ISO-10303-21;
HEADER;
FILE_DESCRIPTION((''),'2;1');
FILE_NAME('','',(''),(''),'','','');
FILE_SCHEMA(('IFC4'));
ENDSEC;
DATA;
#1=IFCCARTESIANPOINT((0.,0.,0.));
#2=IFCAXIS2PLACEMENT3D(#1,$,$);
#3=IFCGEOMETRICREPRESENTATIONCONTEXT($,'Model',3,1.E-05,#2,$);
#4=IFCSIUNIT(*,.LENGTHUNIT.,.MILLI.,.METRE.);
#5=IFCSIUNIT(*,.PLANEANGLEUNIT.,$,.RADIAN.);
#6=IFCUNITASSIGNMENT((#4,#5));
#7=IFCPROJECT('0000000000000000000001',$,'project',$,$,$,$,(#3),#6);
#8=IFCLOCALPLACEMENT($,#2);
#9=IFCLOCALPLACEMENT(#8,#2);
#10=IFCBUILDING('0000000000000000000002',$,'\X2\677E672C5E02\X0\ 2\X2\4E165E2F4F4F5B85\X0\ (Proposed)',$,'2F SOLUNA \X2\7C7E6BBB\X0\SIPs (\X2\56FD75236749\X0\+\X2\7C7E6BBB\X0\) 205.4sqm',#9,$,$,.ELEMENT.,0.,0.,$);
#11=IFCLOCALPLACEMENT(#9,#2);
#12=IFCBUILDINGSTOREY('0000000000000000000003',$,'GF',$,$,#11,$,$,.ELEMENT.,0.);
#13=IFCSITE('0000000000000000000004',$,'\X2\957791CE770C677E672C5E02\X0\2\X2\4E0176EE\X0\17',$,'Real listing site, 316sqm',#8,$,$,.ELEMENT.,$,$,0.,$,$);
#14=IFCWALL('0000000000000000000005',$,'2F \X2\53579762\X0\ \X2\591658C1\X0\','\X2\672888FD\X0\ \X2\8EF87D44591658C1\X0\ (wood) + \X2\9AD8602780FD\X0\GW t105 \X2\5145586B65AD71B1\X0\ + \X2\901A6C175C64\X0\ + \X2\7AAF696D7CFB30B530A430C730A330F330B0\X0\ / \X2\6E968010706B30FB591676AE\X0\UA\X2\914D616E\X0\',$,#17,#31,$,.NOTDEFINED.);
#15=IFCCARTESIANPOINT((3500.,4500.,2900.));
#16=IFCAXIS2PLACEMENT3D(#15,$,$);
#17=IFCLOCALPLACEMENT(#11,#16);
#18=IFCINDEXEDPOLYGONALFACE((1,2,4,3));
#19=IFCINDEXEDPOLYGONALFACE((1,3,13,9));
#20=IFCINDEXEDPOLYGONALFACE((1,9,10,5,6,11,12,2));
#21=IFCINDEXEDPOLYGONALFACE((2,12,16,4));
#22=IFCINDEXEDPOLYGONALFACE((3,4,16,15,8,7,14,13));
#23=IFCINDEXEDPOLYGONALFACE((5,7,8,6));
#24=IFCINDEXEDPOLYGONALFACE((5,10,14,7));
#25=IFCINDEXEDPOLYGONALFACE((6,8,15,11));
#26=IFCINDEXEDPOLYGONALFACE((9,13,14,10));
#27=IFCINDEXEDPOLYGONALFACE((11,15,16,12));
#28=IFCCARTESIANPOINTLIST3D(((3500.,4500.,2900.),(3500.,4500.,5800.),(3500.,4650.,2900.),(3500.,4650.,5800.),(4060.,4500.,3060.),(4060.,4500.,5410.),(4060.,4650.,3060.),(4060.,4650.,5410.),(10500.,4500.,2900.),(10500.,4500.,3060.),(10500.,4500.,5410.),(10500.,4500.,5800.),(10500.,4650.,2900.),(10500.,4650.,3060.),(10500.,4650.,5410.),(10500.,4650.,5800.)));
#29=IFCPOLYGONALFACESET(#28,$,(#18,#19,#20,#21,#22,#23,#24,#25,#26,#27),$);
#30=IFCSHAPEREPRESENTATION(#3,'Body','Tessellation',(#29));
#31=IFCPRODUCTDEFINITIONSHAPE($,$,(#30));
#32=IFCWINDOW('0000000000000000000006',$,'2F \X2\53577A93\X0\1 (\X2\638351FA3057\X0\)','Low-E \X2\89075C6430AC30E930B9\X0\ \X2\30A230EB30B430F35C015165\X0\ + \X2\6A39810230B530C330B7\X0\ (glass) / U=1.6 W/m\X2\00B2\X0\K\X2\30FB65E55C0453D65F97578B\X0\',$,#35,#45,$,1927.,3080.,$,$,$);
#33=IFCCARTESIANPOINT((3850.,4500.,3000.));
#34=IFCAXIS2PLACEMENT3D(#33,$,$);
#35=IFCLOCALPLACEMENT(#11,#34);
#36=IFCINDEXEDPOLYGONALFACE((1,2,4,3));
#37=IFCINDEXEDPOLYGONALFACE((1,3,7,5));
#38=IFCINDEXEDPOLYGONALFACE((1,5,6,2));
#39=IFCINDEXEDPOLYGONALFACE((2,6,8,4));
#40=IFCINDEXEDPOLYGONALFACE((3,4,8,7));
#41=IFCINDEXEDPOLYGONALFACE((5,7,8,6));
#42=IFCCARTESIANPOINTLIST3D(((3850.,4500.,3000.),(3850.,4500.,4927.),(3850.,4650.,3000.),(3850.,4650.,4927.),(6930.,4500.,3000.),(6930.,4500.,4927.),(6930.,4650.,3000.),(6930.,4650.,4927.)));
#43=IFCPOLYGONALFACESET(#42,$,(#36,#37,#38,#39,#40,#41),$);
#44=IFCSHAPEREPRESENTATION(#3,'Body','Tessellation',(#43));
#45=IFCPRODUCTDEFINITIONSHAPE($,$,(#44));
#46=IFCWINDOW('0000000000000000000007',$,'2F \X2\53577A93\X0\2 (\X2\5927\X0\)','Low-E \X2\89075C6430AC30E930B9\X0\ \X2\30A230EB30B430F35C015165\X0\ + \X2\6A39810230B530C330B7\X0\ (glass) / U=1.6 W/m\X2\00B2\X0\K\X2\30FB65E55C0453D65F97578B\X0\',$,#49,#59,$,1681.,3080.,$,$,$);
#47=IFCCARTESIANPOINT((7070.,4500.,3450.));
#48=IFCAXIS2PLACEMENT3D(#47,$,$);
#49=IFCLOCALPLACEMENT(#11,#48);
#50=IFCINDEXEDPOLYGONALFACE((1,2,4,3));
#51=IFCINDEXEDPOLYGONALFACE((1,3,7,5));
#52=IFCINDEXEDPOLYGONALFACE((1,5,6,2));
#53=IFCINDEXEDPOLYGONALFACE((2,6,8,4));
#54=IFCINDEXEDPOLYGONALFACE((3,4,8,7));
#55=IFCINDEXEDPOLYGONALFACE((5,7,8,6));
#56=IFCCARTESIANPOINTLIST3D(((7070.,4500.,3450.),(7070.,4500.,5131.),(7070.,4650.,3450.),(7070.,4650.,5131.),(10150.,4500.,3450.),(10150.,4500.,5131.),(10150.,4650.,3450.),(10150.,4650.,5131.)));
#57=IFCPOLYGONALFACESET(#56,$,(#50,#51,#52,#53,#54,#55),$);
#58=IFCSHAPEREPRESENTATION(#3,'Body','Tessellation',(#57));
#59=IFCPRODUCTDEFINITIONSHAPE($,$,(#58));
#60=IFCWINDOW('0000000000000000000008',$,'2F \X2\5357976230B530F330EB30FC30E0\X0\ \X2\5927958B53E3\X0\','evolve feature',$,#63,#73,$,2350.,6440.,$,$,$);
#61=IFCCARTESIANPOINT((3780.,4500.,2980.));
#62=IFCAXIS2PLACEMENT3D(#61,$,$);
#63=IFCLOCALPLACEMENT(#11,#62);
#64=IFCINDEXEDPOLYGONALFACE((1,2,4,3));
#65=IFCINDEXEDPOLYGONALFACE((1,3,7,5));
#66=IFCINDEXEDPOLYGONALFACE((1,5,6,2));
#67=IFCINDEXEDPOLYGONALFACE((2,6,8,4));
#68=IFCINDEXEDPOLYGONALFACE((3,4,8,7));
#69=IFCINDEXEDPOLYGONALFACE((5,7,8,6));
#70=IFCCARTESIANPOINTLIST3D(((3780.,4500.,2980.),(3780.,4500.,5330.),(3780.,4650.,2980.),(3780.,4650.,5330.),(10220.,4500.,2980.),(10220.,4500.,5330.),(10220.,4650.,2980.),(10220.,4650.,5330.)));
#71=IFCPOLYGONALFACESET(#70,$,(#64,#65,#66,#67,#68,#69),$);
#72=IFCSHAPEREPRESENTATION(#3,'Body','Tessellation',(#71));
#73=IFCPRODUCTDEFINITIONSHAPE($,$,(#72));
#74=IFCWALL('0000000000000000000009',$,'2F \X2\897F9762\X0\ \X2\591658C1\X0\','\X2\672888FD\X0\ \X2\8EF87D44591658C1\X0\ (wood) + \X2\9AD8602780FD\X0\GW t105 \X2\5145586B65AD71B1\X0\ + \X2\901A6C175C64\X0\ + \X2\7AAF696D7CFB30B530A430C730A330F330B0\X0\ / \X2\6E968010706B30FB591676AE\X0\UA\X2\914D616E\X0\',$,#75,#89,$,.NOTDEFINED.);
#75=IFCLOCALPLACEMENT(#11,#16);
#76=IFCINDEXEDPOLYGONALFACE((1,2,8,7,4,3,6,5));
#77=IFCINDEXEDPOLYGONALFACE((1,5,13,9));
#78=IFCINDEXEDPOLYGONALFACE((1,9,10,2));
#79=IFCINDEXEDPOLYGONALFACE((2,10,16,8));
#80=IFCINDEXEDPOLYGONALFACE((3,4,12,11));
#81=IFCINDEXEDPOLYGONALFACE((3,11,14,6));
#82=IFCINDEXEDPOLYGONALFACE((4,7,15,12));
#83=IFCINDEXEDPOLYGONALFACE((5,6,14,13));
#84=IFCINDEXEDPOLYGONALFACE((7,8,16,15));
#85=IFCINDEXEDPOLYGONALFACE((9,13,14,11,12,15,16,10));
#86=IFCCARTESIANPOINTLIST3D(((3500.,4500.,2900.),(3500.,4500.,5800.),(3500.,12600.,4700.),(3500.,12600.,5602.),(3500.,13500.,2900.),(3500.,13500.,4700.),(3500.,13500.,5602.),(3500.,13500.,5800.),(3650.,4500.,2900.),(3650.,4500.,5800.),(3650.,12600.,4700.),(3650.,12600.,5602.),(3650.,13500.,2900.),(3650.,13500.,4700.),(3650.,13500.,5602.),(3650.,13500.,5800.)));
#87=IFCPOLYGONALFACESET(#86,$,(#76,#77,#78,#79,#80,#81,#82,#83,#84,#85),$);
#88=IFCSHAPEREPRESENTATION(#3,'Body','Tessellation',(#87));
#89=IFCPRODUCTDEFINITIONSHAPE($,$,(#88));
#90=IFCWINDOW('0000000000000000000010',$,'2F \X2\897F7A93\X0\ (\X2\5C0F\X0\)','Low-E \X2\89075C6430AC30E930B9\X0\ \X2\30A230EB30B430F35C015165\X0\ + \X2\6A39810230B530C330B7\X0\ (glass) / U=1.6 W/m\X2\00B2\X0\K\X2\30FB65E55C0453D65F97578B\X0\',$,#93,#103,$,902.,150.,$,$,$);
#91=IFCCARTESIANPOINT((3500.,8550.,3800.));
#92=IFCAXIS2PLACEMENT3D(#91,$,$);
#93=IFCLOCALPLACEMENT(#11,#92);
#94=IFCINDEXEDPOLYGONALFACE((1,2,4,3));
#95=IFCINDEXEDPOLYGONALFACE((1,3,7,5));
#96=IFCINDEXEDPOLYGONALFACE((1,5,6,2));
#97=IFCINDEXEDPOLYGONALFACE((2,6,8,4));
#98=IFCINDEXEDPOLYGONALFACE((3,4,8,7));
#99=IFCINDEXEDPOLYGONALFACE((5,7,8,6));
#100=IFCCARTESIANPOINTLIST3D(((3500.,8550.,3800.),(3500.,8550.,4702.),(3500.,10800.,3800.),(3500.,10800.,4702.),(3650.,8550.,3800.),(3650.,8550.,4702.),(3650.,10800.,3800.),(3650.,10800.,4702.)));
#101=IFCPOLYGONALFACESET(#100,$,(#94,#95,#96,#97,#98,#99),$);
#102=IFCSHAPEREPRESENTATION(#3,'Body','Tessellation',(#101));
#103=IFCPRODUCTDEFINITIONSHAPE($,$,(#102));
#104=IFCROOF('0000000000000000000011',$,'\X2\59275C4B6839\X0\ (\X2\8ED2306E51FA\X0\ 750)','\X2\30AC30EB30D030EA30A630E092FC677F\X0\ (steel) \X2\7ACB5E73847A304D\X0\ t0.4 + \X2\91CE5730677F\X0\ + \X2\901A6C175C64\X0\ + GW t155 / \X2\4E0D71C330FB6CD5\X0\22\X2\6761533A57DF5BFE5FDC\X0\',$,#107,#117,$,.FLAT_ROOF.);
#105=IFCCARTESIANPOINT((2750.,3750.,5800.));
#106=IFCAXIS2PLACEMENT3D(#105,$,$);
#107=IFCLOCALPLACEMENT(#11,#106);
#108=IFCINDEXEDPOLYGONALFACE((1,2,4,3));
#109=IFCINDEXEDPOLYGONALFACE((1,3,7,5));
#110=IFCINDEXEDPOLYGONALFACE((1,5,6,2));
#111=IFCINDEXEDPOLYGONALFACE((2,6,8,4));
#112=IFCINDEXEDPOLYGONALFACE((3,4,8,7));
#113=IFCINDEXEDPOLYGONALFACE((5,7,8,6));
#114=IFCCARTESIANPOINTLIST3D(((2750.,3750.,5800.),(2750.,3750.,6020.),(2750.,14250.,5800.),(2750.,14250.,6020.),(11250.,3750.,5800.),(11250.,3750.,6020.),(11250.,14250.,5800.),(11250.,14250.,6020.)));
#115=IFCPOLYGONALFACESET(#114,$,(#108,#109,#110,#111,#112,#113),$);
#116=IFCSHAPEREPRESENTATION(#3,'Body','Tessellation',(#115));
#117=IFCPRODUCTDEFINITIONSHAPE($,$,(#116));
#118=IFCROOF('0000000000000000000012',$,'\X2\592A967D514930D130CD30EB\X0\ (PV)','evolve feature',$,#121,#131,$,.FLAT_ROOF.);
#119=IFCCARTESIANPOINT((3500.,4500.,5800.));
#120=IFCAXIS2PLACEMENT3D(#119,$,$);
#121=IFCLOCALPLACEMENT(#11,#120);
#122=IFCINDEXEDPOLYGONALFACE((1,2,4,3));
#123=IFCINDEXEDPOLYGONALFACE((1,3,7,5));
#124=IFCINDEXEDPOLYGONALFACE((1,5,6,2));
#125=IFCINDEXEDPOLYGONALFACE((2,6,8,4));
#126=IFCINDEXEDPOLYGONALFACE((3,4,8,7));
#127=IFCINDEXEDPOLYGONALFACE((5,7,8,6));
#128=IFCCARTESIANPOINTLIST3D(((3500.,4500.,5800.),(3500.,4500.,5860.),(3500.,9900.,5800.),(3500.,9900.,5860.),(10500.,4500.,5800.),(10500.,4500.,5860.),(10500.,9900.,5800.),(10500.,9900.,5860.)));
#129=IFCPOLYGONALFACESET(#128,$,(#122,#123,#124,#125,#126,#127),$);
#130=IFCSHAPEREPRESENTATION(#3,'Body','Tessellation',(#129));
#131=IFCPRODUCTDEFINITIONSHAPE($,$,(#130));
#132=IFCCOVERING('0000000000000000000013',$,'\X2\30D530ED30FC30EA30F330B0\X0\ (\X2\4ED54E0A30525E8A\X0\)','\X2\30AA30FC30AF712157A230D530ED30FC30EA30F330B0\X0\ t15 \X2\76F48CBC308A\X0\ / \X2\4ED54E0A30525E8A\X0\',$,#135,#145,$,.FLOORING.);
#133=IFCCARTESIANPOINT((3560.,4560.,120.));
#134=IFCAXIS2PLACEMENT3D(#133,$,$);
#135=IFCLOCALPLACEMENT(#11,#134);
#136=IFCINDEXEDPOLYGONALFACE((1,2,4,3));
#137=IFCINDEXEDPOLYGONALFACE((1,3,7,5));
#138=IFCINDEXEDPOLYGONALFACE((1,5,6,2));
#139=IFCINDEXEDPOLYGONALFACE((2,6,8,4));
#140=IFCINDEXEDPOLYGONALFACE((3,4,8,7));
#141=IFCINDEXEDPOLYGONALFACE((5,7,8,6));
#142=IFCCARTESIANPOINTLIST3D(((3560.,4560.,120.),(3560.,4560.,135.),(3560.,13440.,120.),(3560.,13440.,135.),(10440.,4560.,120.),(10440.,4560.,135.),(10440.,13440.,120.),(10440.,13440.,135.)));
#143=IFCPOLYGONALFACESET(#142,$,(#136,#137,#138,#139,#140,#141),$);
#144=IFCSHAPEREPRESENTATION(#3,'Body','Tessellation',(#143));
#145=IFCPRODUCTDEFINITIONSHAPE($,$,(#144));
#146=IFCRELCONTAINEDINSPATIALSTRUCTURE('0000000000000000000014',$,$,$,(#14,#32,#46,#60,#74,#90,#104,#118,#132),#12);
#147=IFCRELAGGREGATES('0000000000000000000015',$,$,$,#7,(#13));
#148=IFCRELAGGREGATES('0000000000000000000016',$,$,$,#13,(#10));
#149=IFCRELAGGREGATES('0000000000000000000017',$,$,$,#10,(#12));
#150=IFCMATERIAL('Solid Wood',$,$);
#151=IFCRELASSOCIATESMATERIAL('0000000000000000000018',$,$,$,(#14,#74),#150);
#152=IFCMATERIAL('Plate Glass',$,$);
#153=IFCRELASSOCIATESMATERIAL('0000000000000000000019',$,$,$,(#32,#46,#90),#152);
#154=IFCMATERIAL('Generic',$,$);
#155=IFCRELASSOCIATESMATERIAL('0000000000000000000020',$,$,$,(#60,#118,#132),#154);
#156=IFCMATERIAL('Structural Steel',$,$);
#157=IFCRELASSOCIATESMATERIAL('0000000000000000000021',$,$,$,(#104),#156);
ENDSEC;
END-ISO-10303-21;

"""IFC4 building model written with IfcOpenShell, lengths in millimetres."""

from ifc_helpers import new_model, si_unit, frame, frame_2d, origin, place, context, project, spatial, rectangle, extrude, material, element, fill, save


model = new_model("IFC4")

# Units and contexts
model_context = context("Model", 3, precision=1e-05, world=origin())
ifc_project = project(units=[si_unit("LENGTHUNIT", "METRE", prefix="MILLI"), si_unit("PLANEANGLEUNIT", "RADIAN")], contexts=[model_context])

# Site, building, storey
site_placement = place(None, origin())
site = spatial("IfcSite", under=ifc_project, at=site_placement, Name="長野県松本市2丁目17", ObjectType="Real listing site, 316sqm", CompositionType="ELEMENT", RefElevation=0.0)
building_placement = place(site_placement, origin())
building = spatial("IfcBuilding", under=site, at=building_placement, Name="松本市 2世帯住宅 (Proposed)", ObjectType="2F SOLUNA 籾殻SIPs (国産杉+籾殻) 205.4sqm", CompositionType="ELEMENT", ElevationOfRefHeight=0.0, ElevationOfTerrain=0.0)
storey_placement = place(building_placement, origin())
storey = spatial("IfcBuildingStorey", under=building, at=storey_placement, Name="GF", CompositionType="ELEMENT", Elevation=0.0)

# Shared definitions
ifc_material_1 = material(Name="Solid Wood")
ifc_material_2 = material(Name="Generic")

# Shared definitions
ifc_material_3 = material(Name="Plate Glass")

# Wall, openings, windows
wall_1_placement = place(storey_placement, frame((3500.0, 4500.0, 2900.0)))
wall_1 = element("IfcWall", 1, at=wall_1_placement, inside=storey, material=ifc_material_1, Name="2F 南面 外壁", Description="木製 軸組外壁 (wood) + 高性能GW t105 充填断熱 + 通気層 + 窯業系サイディング / 準耐火・外皮UA配慮", PredefinedType="NOTDEFINED", context=model_context, shape_type="SweptSolid", body=[
    extrude(rectangle(XDim=7000.0, YDim=150.0, at=frame_2d((3500.0, 75.0))), frame((3500.0, 4500.0, 2900.0)), (0.0, 0.0, 1.0), 2900.0),
])
opening_1_placement = place(storey_placement, frame((3850.0, 4500.0, 3000.0)))
opening_1 = element("IfcOpeningElement", 2, at=opening_1_placement, cuts=wall_1, PredefinedType="NOTDEFINED", context=model_context, shape_type="SweptSolid", body=[
    extrude(rectangle(XDim=3080.0, YDim=150.0, at=frame_2d((1540.0, 75.0))), frame((3850.0, 4500.0, 3000.0)), (0.0, 0.0, 1.0), 1927.0),
])
opening_2_placement = place(storey_placement, frame((7070.0, 4500.0, 3450.0)))
opening_2 = element("IfcOpeningElement", 3, at=opening_2_placement, cuts=wall_1, PredefinedType="NOTDEFINED", context=model_context, shape_type="SweptSolid", body=[
    extrude(rectangle(XDim=3080.0, YDim=150.0, at=frame_2d((1540.0, 75.0))), frame((7070.0, 4500.0, 3450.0)), (0.0, 0.0, 1.0), 1681.0),
])
opening_3_placement = place(storey_placement, frame((3780.0, 4500.0, 2980.0)))
opening_3 = element("IfcOpeningElement", 4, at=opening_3_placement, cuts=wall_1, PredefinedType="NOTDEFINED", context=model_context, shape_type="SweptSolid", body=[
    extrude(rectangle(XDim=6440.0, YDim=150.0, at=frame_2d((3220.0, 75.0))), frame((3780.0, 4500.0, 2980.0)), (0.0, 0.0, 1.0), 2350.0),
])
window_1_placement = place(storey_placement, frame((3850.0, 4500.0, 3000.0)))
window_1 = element("IfcWindow", 5, at=window_1_placement, inside=storey, material=ifc_material_3, Name="2F 南窓1 (掃出し)", Description="Low-E 複層ガラス アルゴン封入 + 樹脂サッシ (glass) / U=1.6 W/m²K・日射取得型", OverallHeight=1927.0, OverallWidth=3080.0, context=model_context, shape_type="SweptSolid", body=[
    extrude(rectangle(XDim=3080.0, YDim=150.0, at=frame_2d((1540.0, 75.0))), frame((3850.0, 4500.0, 3000.0)), (0.0, 0.0, 1.0), 1927.0),
])
fill(opening_1, window_1)
window_2_placement = place(storey_placement, frame((7070.0, 4500.0, 3450.0)))
window_2 = element("IfcWindow", 6, at=window_2_placement, inside=storey, material=ifc_material_3, Name="2F 南窓2 (大)", Description="Low-E 複層ガラス アルゴン封入 + 樹脂サッシ (glass) / U=1.6 W/m²K・日射取得型", OverallHeight=1681.0, OverallWidth=3080.0, context=model_context, shape_type="SweptSolid", body=[
    extrude(rectangle(XDim=3080.0, YDim=150.0, at=frame_2d((1540.0, 75.0))), frame((7070.0, 4500.0, 3450.0)), (0.0, 0.0, 1.0), 1681.0),
])
fill(opening_2, window_2)
window_3_placement = place(storey_placement, frame((3780.0, 4500.0, 2980.0)))
window_3 = element("IfcWindow", 7, at=window_3_placement, inside=storey, material=ifc_material_2, Name="2F 南面サンルーム 大開口", Description="evolve feature", OverallHeight=2350.0, OverallWidth=6440.0, context=model_context, shape_type="SweptSolid", body=[
    extrude(rectangle(XDim=6440.0, YDim=150.0, at=frame_2d((3220.0, 75.0))), frame((3780.0, 4500.0, 2980.0)), (0.0, 0.0, 1.0), 2350.0),
])
fill(opening_3, window_3)

# Wall, opening, window
wall_2_placement = place(storey_placement, frame((3500.0, 4500.0, 2900.0)))
wall_2 = element("IfcWall", 8, at=wall_2_placement, inside=storey, material=ifc_material_1, Name="2F 西面 外壁", Description="木製 軸組外壁 (wood) + 高性能GW t105 充填断熱 + 通気層 + 窯業系サイディング / 準耐火・外皮UA配慮", PredefinedType="NOTDEFINED", context=model_context, shape_type="SweptSolid", body=[
    extrude(rectangle(XDim=150.0, YDim=9000.0, at=frame_2d((75.0, 4500.0))), frame((3500.0, 4500.0, 2900.0)), (0.0, 0.0, 1.0), 2900.0),
])
opening_4_placement = place(storey_placement, frame((3500.0, 8550.0, 3800.0)))
opening_4 = element("IfcOpeningElement", 9, at=opening_4_placement, cuts=wall_2, PredefinedType="NOTDEFINED", context=model_context, shape_type="SweptSolid", body=[
    extrude(rectangle(XDim=150.0, YDim=2250.0, at=frame_2d((75.0, 1125.0))), frame((3500.0, 8550.0, 3800.0)), (0.0, 0.0, 1.0), 902.0),
])
window_4_placement = place(storey_placement, frame((3500.0, 8550.0, 3800.0)))
window_4 = element("IfcWindow", 10, at=window_4_placement, inside=storey, material=ifc_material_3, Name="2F 西窓 (小)", Description="Low-E 複層ガラス アルゴン封入 + 樹脂サッシ (glass) / U=1.6 W/m²K・日射取得型", OverallHeight=902.0, OverallWidth=150.0, context=model_context, shape_type="SweptSolid", body=[
    extrude(rectangle(XDim=150.0, YDim=2250.0, at=frame_2d((75.0, 1125.0))), frame((3500.0, 8550.0, 3800.0)), (0.0, 0.0, 1.0), 902.0),
])
fill(opening_4, window_4)

# Roofs
ifc_material_4 = material(Name="Structural Steel")
roof_1_placement = place(storey_placement, frame((2750.0, 3750.0, 5800.0)))
element("IfcRoof", 11, at=roof_1_placement, inside=storey, material=ifc_material_4, Name="大屋根 (軒の出 750)", Description="ガルバリウム鋼板 (steel) 立平葺き t0.4 + 野地板 + 通気層 + GW t155 / 不燃・法22条区域対応", PredefinedType="FLAT_ROOF", context=model_context, shape_type="SweptSolid", body=[
    extrude(rectangle(XDim=8500.0, YDim=10500.0, at=frame_2d((4250.0, 5250.0))), frame((2750.0, 3750.0, 5800.0)), (0.0, 0.0, 1.0), 220.0),
])
roof_2_placement = place(storey_placement, frame((3500.0, 4500.0, 5800.0)))
element("IfcRoof", 12, at=roof_2_placement, inside=storey, material=ifc_material_2, Name="太陽光パネル (PV)", Description="evolve feature", PredefinedType="FLAT_ROOF", context=model_context, shape_type="SweptSolid", body=[
    extrude(rectangle(XDim=7000.0, YDim=5400.0, at=frame_2d((3500.0, 2700.0))), frame((3500.0, 4500.0, 5800.0)), (0.0, 0.0, 1.0), 60.0),
])

# Covering
covering_placement = place(storey_placement, frame((3560.0, 4560.0, 120.0)))
element("IfcCovering", 13, at=covering_placement, inside=storey, material=ifc_material_2, Name="フローリング (仕上げ床)", Description="オーク無垢フローリング t15 直貼り / 仕上げ床", PredefinedType="FLOORING", context=model_context, shape_type="SweptSolid", body=[
    extrude(rectangle(XDim=6880.0, YDim=8880.0, at=frame_2d((3440.0, 4440.0))), frame((3560.0, 4560.0, 120.0)), (0.0, 0.0, 1.0), 15.0),
])

save(model, "model.ifc")
